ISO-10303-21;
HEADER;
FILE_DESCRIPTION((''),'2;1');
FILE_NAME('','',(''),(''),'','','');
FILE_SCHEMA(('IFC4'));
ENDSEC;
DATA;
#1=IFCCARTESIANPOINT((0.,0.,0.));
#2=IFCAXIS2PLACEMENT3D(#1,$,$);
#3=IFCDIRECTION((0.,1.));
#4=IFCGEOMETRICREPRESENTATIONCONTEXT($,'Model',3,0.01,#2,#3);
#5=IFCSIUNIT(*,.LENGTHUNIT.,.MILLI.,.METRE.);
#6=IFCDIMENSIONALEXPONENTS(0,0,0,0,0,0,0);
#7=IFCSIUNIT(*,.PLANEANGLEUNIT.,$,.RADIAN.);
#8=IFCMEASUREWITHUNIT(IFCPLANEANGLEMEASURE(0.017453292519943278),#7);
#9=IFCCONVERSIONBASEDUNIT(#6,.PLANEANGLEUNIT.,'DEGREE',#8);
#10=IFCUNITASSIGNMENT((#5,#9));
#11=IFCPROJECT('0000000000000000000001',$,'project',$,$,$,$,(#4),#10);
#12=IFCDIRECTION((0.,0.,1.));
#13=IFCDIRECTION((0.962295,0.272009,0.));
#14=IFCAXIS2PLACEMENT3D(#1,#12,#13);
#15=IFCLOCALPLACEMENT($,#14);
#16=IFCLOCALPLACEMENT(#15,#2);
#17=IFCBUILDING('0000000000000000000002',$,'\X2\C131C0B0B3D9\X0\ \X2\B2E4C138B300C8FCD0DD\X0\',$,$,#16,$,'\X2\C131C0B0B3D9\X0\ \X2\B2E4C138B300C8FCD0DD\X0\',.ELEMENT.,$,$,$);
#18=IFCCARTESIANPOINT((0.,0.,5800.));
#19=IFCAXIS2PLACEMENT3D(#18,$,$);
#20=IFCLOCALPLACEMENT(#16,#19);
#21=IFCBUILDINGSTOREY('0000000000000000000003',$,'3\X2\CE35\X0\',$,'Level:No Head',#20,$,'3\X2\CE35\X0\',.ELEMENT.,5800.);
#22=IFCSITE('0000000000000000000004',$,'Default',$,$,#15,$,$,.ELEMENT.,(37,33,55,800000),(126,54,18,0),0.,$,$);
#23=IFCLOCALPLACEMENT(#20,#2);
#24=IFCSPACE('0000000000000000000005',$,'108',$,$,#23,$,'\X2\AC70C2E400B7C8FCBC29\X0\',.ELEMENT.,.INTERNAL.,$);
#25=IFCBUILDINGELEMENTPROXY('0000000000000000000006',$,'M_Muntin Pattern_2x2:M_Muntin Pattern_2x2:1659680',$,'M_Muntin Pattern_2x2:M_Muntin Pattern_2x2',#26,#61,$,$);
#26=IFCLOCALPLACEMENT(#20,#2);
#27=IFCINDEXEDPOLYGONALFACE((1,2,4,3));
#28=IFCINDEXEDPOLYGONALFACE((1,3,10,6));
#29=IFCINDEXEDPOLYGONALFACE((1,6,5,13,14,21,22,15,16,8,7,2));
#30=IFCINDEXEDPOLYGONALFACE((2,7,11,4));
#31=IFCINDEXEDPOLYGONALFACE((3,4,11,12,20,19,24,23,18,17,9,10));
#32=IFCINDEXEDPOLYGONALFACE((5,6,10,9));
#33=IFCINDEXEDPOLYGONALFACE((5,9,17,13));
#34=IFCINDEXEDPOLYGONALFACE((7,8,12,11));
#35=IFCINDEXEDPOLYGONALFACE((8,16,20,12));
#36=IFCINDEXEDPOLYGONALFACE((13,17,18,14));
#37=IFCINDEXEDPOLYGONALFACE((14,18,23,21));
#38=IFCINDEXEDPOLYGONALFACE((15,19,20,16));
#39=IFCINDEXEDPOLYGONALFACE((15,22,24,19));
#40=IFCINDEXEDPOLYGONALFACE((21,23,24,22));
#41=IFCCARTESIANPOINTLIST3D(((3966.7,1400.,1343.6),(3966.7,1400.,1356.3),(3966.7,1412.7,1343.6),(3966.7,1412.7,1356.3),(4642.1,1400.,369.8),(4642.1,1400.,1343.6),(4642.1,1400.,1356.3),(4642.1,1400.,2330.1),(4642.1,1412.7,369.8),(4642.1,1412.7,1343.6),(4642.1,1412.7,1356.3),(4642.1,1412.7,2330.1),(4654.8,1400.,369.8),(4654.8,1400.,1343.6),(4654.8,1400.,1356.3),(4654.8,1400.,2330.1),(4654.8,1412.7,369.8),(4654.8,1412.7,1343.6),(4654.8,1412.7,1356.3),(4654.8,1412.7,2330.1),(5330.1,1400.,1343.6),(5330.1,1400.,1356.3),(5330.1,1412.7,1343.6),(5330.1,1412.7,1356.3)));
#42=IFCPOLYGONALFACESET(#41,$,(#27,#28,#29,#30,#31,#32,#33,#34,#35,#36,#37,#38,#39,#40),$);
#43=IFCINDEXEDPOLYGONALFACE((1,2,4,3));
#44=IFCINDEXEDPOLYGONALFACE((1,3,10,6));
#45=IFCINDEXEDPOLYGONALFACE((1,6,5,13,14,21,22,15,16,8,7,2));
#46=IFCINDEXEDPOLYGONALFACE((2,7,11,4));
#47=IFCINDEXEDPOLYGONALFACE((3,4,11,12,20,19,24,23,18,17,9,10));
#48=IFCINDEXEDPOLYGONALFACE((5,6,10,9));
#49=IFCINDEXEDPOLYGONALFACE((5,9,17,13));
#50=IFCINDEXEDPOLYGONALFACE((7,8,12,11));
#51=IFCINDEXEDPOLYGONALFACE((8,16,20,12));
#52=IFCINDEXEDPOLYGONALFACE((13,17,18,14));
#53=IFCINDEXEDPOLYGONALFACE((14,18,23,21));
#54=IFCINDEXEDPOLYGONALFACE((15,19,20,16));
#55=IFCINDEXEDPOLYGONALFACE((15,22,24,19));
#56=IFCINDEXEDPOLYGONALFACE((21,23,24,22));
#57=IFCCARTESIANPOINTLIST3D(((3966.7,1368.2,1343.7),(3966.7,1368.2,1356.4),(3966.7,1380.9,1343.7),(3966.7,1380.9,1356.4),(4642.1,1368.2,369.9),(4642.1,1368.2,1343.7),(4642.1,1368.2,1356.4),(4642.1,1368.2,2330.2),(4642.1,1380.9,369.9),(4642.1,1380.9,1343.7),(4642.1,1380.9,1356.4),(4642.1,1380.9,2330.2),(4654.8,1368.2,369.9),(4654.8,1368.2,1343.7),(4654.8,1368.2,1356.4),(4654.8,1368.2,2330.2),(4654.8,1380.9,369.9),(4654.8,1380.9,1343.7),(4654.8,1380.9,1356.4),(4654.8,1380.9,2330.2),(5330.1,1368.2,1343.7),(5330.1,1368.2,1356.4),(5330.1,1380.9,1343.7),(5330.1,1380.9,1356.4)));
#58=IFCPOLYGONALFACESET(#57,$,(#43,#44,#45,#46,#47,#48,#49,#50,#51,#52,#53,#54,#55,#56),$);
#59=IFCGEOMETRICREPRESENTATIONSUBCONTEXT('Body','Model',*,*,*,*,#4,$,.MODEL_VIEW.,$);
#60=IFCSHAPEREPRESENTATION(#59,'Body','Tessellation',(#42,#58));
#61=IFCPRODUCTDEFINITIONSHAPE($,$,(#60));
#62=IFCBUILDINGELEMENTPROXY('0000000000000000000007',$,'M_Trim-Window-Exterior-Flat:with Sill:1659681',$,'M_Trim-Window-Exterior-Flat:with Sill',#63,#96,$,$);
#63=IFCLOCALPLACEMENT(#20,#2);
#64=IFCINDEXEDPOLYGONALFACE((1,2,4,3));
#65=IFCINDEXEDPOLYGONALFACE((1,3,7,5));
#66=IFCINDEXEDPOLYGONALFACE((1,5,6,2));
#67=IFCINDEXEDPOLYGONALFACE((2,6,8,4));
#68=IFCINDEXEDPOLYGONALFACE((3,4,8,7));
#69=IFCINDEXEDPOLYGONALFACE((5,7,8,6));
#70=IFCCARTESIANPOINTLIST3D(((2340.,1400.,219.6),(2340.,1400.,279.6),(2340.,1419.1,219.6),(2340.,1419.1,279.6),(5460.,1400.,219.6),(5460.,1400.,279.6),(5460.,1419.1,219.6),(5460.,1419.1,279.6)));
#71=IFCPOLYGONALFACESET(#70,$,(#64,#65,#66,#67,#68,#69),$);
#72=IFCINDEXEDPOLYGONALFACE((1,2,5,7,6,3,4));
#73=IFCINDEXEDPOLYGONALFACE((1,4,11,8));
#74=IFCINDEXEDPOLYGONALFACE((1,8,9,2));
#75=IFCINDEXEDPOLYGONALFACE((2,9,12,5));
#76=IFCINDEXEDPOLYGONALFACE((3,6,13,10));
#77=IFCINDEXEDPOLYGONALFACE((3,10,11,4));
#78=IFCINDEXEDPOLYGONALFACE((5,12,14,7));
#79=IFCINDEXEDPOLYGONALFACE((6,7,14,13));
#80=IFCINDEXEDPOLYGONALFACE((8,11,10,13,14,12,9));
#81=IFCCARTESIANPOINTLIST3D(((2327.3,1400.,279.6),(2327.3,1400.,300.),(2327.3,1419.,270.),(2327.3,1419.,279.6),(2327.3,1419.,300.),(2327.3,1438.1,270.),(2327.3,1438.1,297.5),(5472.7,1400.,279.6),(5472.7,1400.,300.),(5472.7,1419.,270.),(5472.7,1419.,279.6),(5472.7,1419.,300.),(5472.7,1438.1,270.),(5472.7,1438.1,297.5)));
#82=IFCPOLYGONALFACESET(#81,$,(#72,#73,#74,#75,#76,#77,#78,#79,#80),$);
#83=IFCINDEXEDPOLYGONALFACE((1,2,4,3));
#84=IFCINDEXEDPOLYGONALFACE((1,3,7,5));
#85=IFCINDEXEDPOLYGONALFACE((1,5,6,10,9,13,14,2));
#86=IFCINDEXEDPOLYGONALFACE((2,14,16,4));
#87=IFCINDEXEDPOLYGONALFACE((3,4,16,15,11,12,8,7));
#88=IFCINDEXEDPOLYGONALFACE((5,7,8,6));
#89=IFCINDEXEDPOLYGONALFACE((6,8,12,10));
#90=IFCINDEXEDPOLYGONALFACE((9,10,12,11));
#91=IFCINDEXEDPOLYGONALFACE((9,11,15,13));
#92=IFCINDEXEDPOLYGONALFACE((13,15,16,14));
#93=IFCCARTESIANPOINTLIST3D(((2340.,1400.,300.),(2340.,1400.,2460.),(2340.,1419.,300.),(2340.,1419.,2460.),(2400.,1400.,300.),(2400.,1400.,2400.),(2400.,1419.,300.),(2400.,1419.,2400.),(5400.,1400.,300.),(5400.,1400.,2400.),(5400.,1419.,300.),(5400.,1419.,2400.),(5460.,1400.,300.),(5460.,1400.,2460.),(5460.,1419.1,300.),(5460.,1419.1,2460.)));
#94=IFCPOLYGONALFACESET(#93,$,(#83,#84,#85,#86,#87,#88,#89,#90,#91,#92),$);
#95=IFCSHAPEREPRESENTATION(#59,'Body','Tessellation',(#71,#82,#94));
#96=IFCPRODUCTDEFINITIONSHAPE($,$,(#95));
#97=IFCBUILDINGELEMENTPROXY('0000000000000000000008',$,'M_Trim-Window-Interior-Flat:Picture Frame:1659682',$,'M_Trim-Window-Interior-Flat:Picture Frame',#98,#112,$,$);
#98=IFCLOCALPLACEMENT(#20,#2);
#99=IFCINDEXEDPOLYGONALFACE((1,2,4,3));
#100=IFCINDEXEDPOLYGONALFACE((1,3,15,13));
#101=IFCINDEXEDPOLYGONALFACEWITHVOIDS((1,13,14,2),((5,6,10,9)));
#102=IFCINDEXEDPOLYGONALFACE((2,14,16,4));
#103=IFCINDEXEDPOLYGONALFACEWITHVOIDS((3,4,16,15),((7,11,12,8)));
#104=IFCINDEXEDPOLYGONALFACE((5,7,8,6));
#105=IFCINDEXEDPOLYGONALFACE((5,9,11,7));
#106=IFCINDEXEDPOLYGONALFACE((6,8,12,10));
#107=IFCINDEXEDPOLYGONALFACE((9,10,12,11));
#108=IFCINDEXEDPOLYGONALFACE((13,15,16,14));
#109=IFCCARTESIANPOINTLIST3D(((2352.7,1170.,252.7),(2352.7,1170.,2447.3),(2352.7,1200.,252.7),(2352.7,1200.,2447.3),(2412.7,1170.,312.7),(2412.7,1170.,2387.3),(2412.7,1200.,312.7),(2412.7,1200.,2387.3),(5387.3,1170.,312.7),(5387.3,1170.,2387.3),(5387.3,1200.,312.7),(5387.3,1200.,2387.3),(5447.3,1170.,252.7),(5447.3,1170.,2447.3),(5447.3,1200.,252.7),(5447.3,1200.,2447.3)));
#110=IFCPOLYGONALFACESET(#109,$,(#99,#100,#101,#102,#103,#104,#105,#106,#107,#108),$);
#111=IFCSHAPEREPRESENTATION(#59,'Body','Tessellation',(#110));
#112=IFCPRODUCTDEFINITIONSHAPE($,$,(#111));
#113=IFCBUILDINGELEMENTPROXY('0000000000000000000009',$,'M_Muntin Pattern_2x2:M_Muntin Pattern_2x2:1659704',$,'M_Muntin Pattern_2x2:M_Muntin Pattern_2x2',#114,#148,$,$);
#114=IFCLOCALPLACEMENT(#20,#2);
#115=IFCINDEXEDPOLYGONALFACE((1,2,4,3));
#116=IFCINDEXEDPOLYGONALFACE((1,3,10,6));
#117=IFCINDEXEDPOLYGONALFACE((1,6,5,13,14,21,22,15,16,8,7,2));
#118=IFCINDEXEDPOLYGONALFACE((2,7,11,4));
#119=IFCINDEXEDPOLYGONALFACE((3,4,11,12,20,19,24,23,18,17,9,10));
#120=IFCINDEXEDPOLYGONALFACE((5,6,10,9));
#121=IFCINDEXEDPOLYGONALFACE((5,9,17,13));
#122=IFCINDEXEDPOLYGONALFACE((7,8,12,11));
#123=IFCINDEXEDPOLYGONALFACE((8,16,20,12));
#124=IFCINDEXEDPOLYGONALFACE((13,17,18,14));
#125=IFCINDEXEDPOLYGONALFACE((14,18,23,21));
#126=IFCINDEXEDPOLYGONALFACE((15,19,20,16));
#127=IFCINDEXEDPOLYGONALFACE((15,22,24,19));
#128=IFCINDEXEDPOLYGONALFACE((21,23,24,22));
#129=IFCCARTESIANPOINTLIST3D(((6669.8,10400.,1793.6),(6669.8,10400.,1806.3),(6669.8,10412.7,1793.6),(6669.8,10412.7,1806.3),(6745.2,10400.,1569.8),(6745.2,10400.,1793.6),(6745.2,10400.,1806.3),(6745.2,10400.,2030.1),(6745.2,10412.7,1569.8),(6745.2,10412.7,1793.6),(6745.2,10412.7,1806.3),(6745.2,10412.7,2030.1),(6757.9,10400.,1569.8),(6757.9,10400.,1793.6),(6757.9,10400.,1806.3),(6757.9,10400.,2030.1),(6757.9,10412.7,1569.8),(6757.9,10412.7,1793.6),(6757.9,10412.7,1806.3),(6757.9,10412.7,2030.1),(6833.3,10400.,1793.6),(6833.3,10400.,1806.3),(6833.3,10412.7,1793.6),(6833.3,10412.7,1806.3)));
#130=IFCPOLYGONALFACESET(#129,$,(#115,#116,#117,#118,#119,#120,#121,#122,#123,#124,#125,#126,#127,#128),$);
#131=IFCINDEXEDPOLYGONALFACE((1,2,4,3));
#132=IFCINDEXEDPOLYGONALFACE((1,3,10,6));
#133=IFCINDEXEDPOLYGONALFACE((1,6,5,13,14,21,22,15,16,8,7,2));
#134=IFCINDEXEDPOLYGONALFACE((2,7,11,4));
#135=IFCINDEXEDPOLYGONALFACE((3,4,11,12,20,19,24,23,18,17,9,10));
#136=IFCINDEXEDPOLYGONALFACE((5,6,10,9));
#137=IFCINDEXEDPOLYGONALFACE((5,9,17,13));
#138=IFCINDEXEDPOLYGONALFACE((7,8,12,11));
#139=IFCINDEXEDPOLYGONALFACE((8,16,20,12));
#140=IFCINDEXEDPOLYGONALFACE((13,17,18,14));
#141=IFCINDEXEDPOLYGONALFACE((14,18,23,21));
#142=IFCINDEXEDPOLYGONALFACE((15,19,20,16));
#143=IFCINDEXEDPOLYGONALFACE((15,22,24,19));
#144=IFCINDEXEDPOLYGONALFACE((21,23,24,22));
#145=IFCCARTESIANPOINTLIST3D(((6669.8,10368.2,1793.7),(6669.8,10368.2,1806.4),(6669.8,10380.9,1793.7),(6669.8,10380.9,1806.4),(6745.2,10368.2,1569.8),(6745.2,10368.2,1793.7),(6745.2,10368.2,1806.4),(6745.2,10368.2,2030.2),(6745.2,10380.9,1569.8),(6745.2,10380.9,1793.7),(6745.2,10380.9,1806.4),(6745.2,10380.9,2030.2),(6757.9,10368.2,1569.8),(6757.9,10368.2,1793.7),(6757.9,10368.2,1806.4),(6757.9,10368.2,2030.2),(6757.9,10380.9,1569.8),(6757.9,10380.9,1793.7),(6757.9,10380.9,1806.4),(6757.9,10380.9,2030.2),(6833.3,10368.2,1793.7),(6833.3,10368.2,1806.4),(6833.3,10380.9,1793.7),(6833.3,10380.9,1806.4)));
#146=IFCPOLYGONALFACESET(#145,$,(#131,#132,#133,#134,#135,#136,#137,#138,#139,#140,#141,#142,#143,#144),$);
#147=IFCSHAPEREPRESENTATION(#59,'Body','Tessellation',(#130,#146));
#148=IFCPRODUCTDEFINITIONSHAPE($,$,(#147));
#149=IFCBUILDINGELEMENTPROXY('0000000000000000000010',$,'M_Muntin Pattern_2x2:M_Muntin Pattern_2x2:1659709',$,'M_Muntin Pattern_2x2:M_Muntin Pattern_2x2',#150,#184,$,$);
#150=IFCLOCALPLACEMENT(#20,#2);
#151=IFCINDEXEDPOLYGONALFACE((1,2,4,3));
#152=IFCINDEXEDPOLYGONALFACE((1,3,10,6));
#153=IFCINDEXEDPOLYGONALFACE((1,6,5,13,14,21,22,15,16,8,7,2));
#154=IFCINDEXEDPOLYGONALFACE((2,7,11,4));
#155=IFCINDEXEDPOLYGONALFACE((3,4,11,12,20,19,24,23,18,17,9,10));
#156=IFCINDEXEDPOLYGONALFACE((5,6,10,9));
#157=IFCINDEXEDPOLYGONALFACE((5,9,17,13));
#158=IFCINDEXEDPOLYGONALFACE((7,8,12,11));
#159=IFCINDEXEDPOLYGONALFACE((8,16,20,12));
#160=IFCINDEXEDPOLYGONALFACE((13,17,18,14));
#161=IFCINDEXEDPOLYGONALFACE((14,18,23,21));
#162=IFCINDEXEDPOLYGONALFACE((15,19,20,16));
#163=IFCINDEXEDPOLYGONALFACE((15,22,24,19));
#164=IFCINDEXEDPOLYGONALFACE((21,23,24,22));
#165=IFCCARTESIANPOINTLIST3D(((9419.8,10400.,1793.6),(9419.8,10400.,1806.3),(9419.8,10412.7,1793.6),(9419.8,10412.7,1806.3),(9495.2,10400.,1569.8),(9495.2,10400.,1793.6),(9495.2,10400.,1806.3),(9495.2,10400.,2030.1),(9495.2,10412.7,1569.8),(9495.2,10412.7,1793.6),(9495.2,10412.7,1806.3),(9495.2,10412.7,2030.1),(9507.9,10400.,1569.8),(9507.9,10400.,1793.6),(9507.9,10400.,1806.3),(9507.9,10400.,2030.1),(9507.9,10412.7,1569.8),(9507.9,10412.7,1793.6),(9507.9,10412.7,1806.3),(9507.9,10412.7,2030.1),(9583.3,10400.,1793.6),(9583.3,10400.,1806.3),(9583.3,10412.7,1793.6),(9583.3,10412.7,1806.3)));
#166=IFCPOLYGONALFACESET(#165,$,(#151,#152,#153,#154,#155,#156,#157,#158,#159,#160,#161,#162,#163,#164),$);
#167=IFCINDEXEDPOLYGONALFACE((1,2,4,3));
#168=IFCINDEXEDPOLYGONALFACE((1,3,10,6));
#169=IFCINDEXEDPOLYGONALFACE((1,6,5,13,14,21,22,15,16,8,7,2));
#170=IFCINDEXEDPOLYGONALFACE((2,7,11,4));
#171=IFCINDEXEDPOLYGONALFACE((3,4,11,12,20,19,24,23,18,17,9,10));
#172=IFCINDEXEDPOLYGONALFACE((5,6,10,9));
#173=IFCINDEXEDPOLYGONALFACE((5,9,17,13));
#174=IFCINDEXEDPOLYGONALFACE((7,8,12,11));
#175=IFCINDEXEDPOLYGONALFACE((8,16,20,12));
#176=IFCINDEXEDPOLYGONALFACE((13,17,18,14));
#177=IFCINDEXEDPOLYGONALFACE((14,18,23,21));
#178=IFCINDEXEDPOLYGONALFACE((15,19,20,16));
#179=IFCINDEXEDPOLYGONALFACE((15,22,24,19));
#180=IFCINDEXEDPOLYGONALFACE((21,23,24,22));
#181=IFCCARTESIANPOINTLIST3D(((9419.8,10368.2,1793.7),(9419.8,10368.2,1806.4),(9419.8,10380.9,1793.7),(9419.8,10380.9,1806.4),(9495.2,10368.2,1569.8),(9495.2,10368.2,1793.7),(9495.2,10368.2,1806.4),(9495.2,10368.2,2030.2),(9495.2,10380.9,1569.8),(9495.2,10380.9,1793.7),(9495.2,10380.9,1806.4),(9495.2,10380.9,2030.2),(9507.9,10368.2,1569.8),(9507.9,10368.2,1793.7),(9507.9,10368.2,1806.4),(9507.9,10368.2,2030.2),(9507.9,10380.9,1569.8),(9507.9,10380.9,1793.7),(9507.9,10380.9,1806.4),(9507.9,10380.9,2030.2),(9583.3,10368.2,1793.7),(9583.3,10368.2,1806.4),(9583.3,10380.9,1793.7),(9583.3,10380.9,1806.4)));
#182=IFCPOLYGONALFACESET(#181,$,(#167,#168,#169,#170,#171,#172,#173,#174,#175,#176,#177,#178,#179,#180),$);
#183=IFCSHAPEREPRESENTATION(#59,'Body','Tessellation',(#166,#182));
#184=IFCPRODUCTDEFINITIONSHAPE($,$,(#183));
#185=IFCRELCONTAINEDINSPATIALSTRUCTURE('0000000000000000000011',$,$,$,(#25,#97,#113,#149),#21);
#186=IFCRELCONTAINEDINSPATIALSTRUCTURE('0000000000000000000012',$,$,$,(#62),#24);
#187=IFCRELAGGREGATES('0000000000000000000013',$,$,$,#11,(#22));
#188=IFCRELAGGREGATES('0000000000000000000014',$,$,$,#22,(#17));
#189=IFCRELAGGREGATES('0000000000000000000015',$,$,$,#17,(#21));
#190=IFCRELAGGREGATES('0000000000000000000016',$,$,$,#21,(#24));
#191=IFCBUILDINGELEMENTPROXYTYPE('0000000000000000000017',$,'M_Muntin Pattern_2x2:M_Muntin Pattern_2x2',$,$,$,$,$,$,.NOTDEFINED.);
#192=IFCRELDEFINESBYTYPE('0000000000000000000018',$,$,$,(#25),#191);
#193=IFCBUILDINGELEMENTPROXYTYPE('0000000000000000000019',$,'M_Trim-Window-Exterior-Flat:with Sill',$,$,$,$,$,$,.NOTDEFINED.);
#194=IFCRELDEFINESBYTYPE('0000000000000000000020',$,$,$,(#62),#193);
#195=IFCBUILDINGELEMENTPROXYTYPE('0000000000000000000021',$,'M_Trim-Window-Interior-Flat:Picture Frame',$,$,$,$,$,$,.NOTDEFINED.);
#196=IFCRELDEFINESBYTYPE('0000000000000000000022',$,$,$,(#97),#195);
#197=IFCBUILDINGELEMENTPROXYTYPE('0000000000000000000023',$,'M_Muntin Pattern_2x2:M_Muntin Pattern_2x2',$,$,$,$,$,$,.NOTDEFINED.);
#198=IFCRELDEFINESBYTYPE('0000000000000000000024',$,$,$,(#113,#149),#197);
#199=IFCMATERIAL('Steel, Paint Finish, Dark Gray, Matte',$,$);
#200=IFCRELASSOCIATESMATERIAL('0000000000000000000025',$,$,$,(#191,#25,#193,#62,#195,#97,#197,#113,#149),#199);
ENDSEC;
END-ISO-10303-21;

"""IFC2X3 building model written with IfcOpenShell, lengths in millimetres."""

from ifc_helpers import new_model, entity, si_unit, converted_unit, direction, frame, frame_2d, origin, place, context, subcontext, project, spatial, polyline, rectangle, outline, extrude, source, transform, mapped, material, type_object, type_shapes, element, save


model = new_model("IFC2X3")

# Units and contexts
model_context = context("Model", 3, precision=0.01, world=origin(), true_north=direction((0.0, 1.0)))
body_context = subcontext(model_context, "Body", "Model", "MODEL_VIEW")
ifc_project = project(units=[si_unit("LENGTHUNIT", "METRE", prefix="MILLI"), converted_unit("PLANEANGLEUNIT", "DEGREE", entity("IfcPlaneAngleMeasure", 0.017453292519943278), si_unit("PLANEANGLEUNIT", "RADIAN"), dimensions=[0, 0, 0, 0, 0, 0, 0])], contexts=[model_context])

# Site, building, storey
site_placement = place(None, frame((0.0, 0.0, 0.0), z_axis=(0.0, 0.0, 1.0), x_axis=(0.962295, 0.272009, 0.0)))
site = spatial("IfcSite", under=ifc_project, at=site_placement, Name="Default", CompositionType="ELEMENT", RefLatitude=(37, 33, 55, 800000), RefLongitude=(126, 54, 18, 0), RefElevation=0.0)
building_placement = place(site_placement, origin())
building = spatial("IfcBuilding", under=site, at=building_placement, Name="성산동 다세대주택", LongName="성산동 다세대주택", CompositionType="ELEMENT")
storey_placement = place(building_placement, frame((0.0, 0.0, 5800.0)))
storey = spatial("IfcBuildingStorey", under=building, at=storey_placement, Name="3층", ObjectType="Level:No Head", LongName="3층", CompositionType="ELEMENT", Elevation=5800.0)

# Shared definitions
space_1_placement = place(storey_placement, origin())
space_1 = spatial("IfcSpace", under=storey, at=space_1_placement, Name="108", LongName="거실·주방", CompositionType="ELEMENT", InteriorOrExteriorSpace="INTERNAL")

# Building element proxies
ifc_material_1 = material(Name="Steel, Paint Finish, Dark Gray, Matte")
building_element_proxy_type_1 = type_object("IfcBuildingElementProxyType", Name="M_Muntin Pattern_2x2:M_Muntin Pattern_2x2", PredefinedType="NOTDEFINED", material=ifc_material_1)
shared_shape_1 = source(origin(), body_context, "Body", "SweptSolid", [
    extrude(outline(polyline([(6.4, -6.4), (980.1, -6.4), (980.1, 6.3), (6.4, 6.3), (6.4, 681.7), (-6.3, 681.7), (-6.3, 6.3), (-980.2, 6.3), (-980.2, -6.4), (-6.3, -6.4), (-6.3, -681.7), (6.4, -681.7), (6.4, -6.4)])), frame((0.0, -22.2, 980.1), z_axis=(0.0, 1.0, 0.0), x_axis=(0.0, 0.0, 1.0)), (0.0, 0.0, 1.0), 12.7),
    extrude(outline(polyline([(6.4, -6.4), (980.2, -6.4), (980.2, 6.3), (6.4, 6.3), (6.4, 681.7), (-6.3, 681.7), (-6.3, 6.3), (-980.2, 6.3), (-980.2, -6.4), (-6.3, -6.4), (-6.3, -681.7), (6.4, -681.7), (6.4, -6.4)])), frame((0.0, 9.5, 980.2), z_axis=(0.0, 1.0, 0.0), x_axis=(0.0, 0.0, 1.0)), (0.0, 0.0, 1.0), 12.7),
])
type_shapes(building_element_proxy_type_1, [shared_shape_1])
proxy_1_placement = place(storey_placement, frame((4648.4, 1390.5, 369.9), z_axis=(0.0, 0.0, 1.0), x_axis=(-1.0, 0.0, 0.0)))
element("IfcBuildingElementProxy", 1, at=proxy_1_placement, inside=storey, type_object=building_element_proxy_type_1, material=ifc_material_1, Name="M_Muntin Pattern_2x2:M_Muntin Pattern_2x2:1659680", ObjectType="M_Muntin Pattern_2x2:M_Muntin Pattern_2x2", context=body_context, shape_type="MappedRepresentation", body=[
    mapped(shared_shape_1, transform((0.0, 0.0, 0.0), scale=1.0)),
])
building_element_proxy_type_2 = type_object("IfcBuildingElementProxyType", Name="M_Trim-Window-Exterior-Flat:with Sill", PredefinedType="NOTDEFINED", material=ifc_material_1)
shared_shape_2 = source(origin(), body_context, "Body", "SweptSolid", [
    extrude(rectangle(XDim=3120.0, YDim=60.0, at=frame_2d((0.0, 0.0), x_axis=(1.0, 0.0))), frame((0.0, -2150.4, 0.0), z_axis=(0.0, 0.0, 1.0), x_axis=(-1.0, 0.0, 0.0)), (0.0, 0.0, 1.0), 19.0),
    extrude(outline(polyline([(-19.0, -15.2), (0.0, -15.2), (0.0, -5.7), (19.0, -5.7), (19.0, 14.8), (0.0, 14.8), (-19.0, 12.3), (-19.0, -15.2)])), frame((-1572.7, -2114.8, 19.0), z_axis=(1.0, 0.0, 0.0), x_axis=(0.0, 0.0, -1.0)), (0.0, 0.0, 1.0), 3145.4),
    extrude(outline(polyline([(-1095.0, -1560.0), (1065.0, -1560.0), (1065.0, -1500.0), (-1035.0, -1500.0), (-1035.0, 1500.0), (1065.0, 1500.0), (1065.0, 1560.0), (-1095.0, 1560.0), (-1095.0, -1560.0)])), frame((0.0, -1035.0, 0.0), z_axis=(0.0, 0.0, 1.0), x_axis=(0.0, -1.0, 0.0)), (0.0, 0.0, 1.0), 19.0),
])
type_shapes(building_element_proxy_type_2, [shared_shape_2])
proxy_2_placement = place(space_1_placement, frame((3900.0, 1400.0, 2400.0), z_axis=(0.0, 1.0, 0.0), x_axis=(-1.0, 0.0, 0.0)))
element("IfcBuildingElementProxy", 2, at=proxy_2_placement, inside=space_1, type_object=building_element_proxy_type_2, material=ifc_material_1, Name="M_Trim-Window-Exterior-Flat:with Sill:1659681", ObjectType="M_Trim-Window-Exterior-Flat:with Sill", context=body_context, shape_type="MappedRepresentation", body=[
    mapped(shared_shape_2, transform((0.0, 0.0, 0.0), scale=1.0)),
])
building_element_proxy_type_3 = type_object("IfcBuildingElementProxyType", Name="M_Trim-Window-Interior-Flat:Picture Frame", PredefinedType="NOTDEFINED", material=ifc_material_1)
shared_shape_3 = source(origin(), body_context, "Body", "SweptSolid", [
    extrude(outline(polyline([(-1547.3, -1097.3), (1547.3, -1097.3), (1547.3, 1097.3), (-1547.3, 1097.3), (-1547.3, -1097.3)]), holes=[polyline([(-1487.3, -1037.3), (-1487.3, 1037.3), (1487.3, 1037.3), (1487.3, -1037.3), (-1487.3, -1037.3)])]), frame((0.0, -1050.0, 0.0), z_axis=(0.0, 0.0, 1.0), x_axis=(-1.0, 0.0, 0.0)), (0.0, 0.0, 1.0), 30.0),
])
type_shapes(building_element_proxy_type_3, [shared_shape_3])
proxy_3_placement = place(storey_placement, frame((3900.0, 1200.0, 2400.0), z_axis=(0.0, -1.0, 0.0), x_axis=(1.0, 0.0, 0.0)))
element("IfcBuildingElementProxy", 3, at=proxy_3_placement, inside=storey, type_object=building_element_proxy_type_3, material=ifc_material_1, Name="M_Trim-Window-Interior-Flat:Picture Frame:1659682", ObjectType="M_Trim-Window-Interior-Flat:Picture Frame", context=body_context, shape_type="MappedRepresentation", body=[
    mapped(shared_shape_3, transform((0.0, 0.0, 0.0), scale=1.0)),
])
building_element_proxy_type_4 = type_object("IfcBuildingElementProxyType", Name="M_Muntin Pattern_2x2:M_Muntin Pattern_2x2", PredefinedType="NOTDEFINED", material=ifc_material_1)
shared_shape_4 = source(origin(), body_context, "Body", "SweptSolid", [
    extrude(outline(polyline([(6.4, -6.4), (230.1, -6.4), (230.1, 6.3), (6.4, 6.3), (6.4, 81.7), (-6.3, 81.7), (-6.3, 6.3), (-230.2, 6.3), (-230.2, -6.4), (-6.3, -6.4), (-6.3, -81.7), (6.4, -81.7), (6.4, -6.4)])), frame((0.0, 9.5, 230.1), z_axis=(0.0, 1.0, 0.0), x_axis=(0.0, 0.0, 1.0)), (0.0, 0.0, 1.0), 12.7),
    extrude(outline(polyline([(6.4, -6.4), (230.2, -6.4), (230.2, 6.3), (6.4, 6.3), (6.4, 81.7), (-6.3, 81.7), (-6.3, 6.3), (-230.2, 6.3), (-230.2, -6.4), (-6.3, -6.4), (-6.3, -81.7), (6.4, -81.7), (6.4, -6.4)])), frame((0.0, -22.2, 230.2), z_axis=(0.0, 1.0, 0.0), x_axis=(0.0, 0.0, 1.0)), (0.0, 0.0, 1.0), 12.7),
])
type_shapes(building_element_proxy_type_4, [shared_shape_4])
for number, where, name in (
    (4, (6751.6, 10390.5, 1569.8), "M_Muntin Pattern_2x2:M_Muntin Pattern_2x2:1659704"),
    (5, (9501.6, 10390.5, 1569.8), "M_Muntin Pattern_2x2:M_Muntin Pattern_2x2:1659709"),
):
    element("IfcBuildingElementProxy", number, at=place(storey_placement, frame(where)), inside=storey, type_object=building_element_proxy_type_4, material=ifc_material_1, Name=name, ObjectType="M_Muntin Pattern_2x2:M_Muntin Pattern_2x2", context=body_context, shape_type="MappedRepresentation", body=[
        mapped(shared_shape_4, transform((0.0, 0.0, 0.0), scale=1.0)),
    ])

save(model, "model.ifc")
